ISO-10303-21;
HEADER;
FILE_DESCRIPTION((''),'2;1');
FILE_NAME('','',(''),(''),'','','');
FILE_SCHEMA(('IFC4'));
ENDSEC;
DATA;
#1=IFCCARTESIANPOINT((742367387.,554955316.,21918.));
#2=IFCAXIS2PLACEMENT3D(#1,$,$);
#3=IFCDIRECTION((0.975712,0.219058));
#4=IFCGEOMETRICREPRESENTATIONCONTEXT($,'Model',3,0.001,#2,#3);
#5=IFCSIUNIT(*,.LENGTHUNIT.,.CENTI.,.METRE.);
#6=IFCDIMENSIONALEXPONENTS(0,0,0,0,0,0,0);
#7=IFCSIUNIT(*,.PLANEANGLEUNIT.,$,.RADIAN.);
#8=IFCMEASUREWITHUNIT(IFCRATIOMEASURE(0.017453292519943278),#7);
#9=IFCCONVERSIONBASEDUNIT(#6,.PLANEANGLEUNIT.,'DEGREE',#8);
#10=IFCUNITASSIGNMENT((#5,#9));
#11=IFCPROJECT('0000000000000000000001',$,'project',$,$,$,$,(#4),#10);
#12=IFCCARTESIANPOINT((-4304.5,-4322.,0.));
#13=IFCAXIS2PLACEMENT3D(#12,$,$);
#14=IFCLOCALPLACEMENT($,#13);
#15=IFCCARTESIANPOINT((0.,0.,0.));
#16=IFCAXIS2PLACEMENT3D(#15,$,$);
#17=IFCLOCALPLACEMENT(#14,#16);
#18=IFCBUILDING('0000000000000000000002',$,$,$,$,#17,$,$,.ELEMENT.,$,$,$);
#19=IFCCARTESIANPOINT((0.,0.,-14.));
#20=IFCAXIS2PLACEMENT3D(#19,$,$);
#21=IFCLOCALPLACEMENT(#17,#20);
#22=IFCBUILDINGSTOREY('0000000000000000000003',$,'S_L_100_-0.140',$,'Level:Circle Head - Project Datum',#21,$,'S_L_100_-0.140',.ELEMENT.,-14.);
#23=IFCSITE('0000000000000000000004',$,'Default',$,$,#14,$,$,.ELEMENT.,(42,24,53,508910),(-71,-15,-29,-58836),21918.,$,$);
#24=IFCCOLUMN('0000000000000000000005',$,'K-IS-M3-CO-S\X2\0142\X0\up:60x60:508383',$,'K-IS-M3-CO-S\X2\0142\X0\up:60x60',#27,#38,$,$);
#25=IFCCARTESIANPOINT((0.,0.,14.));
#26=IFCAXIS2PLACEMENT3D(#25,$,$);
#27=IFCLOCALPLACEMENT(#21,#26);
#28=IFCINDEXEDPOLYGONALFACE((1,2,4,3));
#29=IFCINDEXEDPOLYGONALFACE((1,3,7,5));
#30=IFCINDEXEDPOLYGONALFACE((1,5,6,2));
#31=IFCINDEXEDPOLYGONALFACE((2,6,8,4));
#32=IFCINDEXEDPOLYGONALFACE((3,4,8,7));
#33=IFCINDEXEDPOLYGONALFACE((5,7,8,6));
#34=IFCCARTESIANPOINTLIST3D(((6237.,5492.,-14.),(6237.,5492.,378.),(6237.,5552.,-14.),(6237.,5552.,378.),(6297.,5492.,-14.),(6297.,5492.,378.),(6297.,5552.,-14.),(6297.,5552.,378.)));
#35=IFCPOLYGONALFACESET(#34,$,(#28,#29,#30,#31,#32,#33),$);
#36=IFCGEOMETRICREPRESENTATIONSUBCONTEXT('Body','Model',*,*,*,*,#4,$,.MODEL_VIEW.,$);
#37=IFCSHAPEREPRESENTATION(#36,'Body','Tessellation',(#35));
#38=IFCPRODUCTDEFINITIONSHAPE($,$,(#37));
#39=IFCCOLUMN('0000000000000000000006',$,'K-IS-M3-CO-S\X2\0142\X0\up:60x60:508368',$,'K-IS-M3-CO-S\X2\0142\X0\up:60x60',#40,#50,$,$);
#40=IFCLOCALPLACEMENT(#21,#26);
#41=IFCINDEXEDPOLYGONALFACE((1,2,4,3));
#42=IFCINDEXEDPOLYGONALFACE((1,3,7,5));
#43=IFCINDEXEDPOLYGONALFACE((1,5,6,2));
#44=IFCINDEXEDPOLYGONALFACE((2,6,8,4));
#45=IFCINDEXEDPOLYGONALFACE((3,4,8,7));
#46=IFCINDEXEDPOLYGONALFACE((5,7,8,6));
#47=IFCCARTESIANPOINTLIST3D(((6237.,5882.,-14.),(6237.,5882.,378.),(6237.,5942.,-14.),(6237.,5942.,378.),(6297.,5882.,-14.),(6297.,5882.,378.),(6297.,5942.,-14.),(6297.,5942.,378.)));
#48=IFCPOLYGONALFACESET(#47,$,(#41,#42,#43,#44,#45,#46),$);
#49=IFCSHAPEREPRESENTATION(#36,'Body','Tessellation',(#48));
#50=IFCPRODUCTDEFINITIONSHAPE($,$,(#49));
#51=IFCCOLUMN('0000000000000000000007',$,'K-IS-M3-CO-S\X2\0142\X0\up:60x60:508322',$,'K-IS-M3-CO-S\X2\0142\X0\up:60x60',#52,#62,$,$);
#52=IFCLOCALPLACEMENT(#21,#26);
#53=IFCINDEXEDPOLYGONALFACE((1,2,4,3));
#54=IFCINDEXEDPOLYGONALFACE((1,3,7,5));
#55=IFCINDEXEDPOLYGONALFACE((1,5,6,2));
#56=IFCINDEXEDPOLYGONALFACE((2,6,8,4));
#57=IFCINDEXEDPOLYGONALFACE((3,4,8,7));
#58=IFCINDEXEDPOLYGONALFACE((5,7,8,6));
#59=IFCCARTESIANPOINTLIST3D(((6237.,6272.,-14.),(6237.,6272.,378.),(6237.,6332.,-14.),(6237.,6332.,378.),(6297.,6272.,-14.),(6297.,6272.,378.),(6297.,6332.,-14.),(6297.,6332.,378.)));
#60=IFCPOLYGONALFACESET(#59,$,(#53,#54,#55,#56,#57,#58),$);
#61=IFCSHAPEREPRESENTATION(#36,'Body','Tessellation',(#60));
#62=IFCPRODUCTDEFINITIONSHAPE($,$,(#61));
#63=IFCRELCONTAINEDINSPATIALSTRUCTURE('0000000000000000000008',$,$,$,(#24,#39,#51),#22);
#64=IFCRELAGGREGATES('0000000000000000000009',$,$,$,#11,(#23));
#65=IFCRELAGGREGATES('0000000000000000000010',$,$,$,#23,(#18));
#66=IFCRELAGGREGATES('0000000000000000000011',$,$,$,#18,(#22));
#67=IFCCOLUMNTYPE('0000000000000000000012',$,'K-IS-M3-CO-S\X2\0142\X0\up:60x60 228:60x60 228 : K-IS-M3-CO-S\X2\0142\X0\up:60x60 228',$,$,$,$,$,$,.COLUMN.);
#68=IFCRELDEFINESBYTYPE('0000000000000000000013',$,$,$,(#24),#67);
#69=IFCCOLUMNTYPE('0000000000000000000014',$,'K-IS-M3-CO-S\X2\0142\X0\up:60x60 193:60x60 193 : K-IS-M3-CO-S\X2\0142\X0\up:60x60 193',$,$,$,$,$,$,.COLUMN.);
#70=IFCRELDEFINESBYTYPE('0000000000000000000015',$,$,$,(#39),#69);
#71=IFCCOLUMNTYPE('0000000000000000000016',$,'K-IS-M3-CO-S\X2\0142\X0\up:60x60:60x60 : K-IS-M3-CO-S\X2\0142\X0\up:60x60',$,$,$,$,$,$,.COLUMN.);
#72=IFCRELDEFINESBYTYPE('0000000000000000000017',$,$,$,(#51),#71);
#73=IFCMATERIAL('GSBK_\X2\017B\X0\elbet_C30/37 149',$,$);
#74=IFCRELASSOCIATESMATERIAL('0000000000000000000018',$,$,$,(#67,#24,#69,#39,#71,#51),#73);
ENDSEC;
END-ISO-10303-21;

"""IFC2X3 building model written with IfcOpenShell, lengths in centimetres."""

from ifc_helpers import new_model, entity, si_unit, converted_unit, direction, frame, frame_2d, origin, origin_2d_with_axis, place, context, subcontext, project, spatial, rectangle, extrude, source, transform, mapped, material, type_object, type_shapes, element, save


model = new_model("IFC2X3")

# Units and contexts
model_context = context("Model", 3, precision=0.001, world=frame((742367387.0, 554955316.0, 21918.0)), true_north=direction((0.975712, 0.219058)))
body_context = subcontext(model_context, "Body", "Model", "MODEL_VIEW")
ifc_project = project(units=[si_unit("LENGTHUNIT", "METRE", prefix="CENTI"), converted_unit("PLANEANGLEUNIT", "DEGREE", entity("IfcRatioMeasure", 0.017453292519943278), si_unit("PLANEANGLEUNIT", "RADIAN"), dimensions=[0, 0, 0, 0, 0, 0, 0])], contexts=[model_context])

# Site, building, storey
site_placement = place(None, frame((-4304.5, -4322.0, 0.0)))
site = spatial("IfcSite", under=ifc_project, at=site_placement, Name="Default", CompositionType="ELEMENT", RefLatitude=(42, 24, 53, 508910), RefLongitude=(-71, -15, -29, -58836), RefElevation=21918.0)
building_placement = place(site_placement, origin())
building = spatial("IfcBuilding", under=site, at=building_placement, CompositionType="ELEMENT")
storey_placement = place(building_placement, frame((0.0, 0.0, -14.0)))
storey = spatial("IfcBuildingStorey", under=building, at=storey_placement, Name="S_L_100_-0.140", ObjectType="Level:Circle Head - Project Datum", LongName="S_L_100_-0.140", CompositionType="ELEMENT", Elevation=-14.0)

# Columns
ifc_material_1 = material(Name="GSBK_Żelbet_C30/37 149")
column_type_1 = type_object("IfcColumnType", Name="K-IS-M3-CO-Słup:60x60 228:60x60 228 : K-IS-M3-CO-Słup:60x60 228", PredefinedType="COLUMN", material=ifc_material_1)
shared_shape_1 = source(origin(), body_context, "Body", "SweptSolid", [
    extrude(rectangle(XDim=60.0, YDim=60.0, at=origin_2d_with_axis()), frame((6267.0, 5522.0, -14.0), z_axis=(0.0, 0.0, 1.0), x_axis=(0.0, -1.0, 0.0)), (0.0, 0.0, 1.0), 392.0),
])
type_shapes(column_type_1, [shared_shape_1])
column_1_placement = place(storey_placement, frame((0.0, 0.0, 14.0)))
element("IfcColumn", 1, at=column_1_placement, inside=storey, type_object=column_type_1, material=ifc_material_1, Name="K-IS-M3-CO-Słup:60x60:508383", ObjectType="K-IS-M3-CO-Słup:60x60", context=body_context, shape_type="MappedRepresentation", body=[
    mapped(shared_shape_1, transform((0.0, 0.0, 0.0), scale=1.0)),
])
column_type_2 = type_object("IfcColumnType", Name="K-IS-M3-CO-Słup:60x60 193:60x60 193 : K-IS-M3-CO-Słup:60x60 193", PredefinedType="COLUMN", material=ifc_material_1)
shared_shape_2 = source(origin(), body_context, "Body", "SweptSolid", [
    extrude(rectangle(XDim=60.0, YDim=60.0, at=frame_2d((0.0, 0.0), x_axis=(1.0, 0.0))), frame((6267.0, 5912.0, -14.0), z_axis=(0.0, 0.0, 1.0), x_axis=(0.0, -1.0, 0.0)), (0.0, 0.0, 1.0), 392.0),
])
type_shapes(column_type_2, [shared_shape_2])
column_2_placement = place(storey_placement, frame((0.0, 0.0, 14.0)))
element("IfcColumn", 2, at=column_2_placement, inside=storey, type_object=column_type_2, material=ifc_material_1, Name="K-IS-M3-CO-Słup:60x60:508368", ObjectType="K-IS-M3-CO-Słup:60x60", context=body_context, shape_type="MappedRepresentation", body=[
    mapped(shared_shape_2, transform((0.0, 0.0, 0.0), scale=1.0)),
])
column_type_3 = type_object("IfcColumnType", Name="K-IS-M3-CO-Słup:60x60:60x60 : K-IS-M3-CO-Słup:60x60", PredefinedType="COLUMN", material=ifc_material_1)
shared_shape_3 = source(origin(), body_context, "Body", "SweptSolid", [
    extrude(rectangle(XDim=60.0, YDim=60.0, at=origin_2d_with_axis()), frame((6267.0, 6302.0, -14.0), z_axis=(0.0, 0.0, 1.0), x_axis=(0.0, -1.0, 0.0)), (0.0, 0.0, 1.0), 392.0),
])
type_shapes(column_type_3, [shared_shape_3])
column_3_placement = place(storey_placement, frame((0.0, 0.0, 14.0)))
element("IfcColumn", 3, at=column_3_placement, inside=storey, type_object=column_type_3, material=ifc_material_1, Name="K-IS-M3-CO-Słup:60x60:508322", ObjectType="K-IS-M3-CO-Słup:60x60", context=body_context, shape_type="MappedRepresentation", body=[
    mapped(shared_shape_3, transform((0.0, 0.0, 0.0), scale=1.0)),
])

save(model, "model.ifc")
